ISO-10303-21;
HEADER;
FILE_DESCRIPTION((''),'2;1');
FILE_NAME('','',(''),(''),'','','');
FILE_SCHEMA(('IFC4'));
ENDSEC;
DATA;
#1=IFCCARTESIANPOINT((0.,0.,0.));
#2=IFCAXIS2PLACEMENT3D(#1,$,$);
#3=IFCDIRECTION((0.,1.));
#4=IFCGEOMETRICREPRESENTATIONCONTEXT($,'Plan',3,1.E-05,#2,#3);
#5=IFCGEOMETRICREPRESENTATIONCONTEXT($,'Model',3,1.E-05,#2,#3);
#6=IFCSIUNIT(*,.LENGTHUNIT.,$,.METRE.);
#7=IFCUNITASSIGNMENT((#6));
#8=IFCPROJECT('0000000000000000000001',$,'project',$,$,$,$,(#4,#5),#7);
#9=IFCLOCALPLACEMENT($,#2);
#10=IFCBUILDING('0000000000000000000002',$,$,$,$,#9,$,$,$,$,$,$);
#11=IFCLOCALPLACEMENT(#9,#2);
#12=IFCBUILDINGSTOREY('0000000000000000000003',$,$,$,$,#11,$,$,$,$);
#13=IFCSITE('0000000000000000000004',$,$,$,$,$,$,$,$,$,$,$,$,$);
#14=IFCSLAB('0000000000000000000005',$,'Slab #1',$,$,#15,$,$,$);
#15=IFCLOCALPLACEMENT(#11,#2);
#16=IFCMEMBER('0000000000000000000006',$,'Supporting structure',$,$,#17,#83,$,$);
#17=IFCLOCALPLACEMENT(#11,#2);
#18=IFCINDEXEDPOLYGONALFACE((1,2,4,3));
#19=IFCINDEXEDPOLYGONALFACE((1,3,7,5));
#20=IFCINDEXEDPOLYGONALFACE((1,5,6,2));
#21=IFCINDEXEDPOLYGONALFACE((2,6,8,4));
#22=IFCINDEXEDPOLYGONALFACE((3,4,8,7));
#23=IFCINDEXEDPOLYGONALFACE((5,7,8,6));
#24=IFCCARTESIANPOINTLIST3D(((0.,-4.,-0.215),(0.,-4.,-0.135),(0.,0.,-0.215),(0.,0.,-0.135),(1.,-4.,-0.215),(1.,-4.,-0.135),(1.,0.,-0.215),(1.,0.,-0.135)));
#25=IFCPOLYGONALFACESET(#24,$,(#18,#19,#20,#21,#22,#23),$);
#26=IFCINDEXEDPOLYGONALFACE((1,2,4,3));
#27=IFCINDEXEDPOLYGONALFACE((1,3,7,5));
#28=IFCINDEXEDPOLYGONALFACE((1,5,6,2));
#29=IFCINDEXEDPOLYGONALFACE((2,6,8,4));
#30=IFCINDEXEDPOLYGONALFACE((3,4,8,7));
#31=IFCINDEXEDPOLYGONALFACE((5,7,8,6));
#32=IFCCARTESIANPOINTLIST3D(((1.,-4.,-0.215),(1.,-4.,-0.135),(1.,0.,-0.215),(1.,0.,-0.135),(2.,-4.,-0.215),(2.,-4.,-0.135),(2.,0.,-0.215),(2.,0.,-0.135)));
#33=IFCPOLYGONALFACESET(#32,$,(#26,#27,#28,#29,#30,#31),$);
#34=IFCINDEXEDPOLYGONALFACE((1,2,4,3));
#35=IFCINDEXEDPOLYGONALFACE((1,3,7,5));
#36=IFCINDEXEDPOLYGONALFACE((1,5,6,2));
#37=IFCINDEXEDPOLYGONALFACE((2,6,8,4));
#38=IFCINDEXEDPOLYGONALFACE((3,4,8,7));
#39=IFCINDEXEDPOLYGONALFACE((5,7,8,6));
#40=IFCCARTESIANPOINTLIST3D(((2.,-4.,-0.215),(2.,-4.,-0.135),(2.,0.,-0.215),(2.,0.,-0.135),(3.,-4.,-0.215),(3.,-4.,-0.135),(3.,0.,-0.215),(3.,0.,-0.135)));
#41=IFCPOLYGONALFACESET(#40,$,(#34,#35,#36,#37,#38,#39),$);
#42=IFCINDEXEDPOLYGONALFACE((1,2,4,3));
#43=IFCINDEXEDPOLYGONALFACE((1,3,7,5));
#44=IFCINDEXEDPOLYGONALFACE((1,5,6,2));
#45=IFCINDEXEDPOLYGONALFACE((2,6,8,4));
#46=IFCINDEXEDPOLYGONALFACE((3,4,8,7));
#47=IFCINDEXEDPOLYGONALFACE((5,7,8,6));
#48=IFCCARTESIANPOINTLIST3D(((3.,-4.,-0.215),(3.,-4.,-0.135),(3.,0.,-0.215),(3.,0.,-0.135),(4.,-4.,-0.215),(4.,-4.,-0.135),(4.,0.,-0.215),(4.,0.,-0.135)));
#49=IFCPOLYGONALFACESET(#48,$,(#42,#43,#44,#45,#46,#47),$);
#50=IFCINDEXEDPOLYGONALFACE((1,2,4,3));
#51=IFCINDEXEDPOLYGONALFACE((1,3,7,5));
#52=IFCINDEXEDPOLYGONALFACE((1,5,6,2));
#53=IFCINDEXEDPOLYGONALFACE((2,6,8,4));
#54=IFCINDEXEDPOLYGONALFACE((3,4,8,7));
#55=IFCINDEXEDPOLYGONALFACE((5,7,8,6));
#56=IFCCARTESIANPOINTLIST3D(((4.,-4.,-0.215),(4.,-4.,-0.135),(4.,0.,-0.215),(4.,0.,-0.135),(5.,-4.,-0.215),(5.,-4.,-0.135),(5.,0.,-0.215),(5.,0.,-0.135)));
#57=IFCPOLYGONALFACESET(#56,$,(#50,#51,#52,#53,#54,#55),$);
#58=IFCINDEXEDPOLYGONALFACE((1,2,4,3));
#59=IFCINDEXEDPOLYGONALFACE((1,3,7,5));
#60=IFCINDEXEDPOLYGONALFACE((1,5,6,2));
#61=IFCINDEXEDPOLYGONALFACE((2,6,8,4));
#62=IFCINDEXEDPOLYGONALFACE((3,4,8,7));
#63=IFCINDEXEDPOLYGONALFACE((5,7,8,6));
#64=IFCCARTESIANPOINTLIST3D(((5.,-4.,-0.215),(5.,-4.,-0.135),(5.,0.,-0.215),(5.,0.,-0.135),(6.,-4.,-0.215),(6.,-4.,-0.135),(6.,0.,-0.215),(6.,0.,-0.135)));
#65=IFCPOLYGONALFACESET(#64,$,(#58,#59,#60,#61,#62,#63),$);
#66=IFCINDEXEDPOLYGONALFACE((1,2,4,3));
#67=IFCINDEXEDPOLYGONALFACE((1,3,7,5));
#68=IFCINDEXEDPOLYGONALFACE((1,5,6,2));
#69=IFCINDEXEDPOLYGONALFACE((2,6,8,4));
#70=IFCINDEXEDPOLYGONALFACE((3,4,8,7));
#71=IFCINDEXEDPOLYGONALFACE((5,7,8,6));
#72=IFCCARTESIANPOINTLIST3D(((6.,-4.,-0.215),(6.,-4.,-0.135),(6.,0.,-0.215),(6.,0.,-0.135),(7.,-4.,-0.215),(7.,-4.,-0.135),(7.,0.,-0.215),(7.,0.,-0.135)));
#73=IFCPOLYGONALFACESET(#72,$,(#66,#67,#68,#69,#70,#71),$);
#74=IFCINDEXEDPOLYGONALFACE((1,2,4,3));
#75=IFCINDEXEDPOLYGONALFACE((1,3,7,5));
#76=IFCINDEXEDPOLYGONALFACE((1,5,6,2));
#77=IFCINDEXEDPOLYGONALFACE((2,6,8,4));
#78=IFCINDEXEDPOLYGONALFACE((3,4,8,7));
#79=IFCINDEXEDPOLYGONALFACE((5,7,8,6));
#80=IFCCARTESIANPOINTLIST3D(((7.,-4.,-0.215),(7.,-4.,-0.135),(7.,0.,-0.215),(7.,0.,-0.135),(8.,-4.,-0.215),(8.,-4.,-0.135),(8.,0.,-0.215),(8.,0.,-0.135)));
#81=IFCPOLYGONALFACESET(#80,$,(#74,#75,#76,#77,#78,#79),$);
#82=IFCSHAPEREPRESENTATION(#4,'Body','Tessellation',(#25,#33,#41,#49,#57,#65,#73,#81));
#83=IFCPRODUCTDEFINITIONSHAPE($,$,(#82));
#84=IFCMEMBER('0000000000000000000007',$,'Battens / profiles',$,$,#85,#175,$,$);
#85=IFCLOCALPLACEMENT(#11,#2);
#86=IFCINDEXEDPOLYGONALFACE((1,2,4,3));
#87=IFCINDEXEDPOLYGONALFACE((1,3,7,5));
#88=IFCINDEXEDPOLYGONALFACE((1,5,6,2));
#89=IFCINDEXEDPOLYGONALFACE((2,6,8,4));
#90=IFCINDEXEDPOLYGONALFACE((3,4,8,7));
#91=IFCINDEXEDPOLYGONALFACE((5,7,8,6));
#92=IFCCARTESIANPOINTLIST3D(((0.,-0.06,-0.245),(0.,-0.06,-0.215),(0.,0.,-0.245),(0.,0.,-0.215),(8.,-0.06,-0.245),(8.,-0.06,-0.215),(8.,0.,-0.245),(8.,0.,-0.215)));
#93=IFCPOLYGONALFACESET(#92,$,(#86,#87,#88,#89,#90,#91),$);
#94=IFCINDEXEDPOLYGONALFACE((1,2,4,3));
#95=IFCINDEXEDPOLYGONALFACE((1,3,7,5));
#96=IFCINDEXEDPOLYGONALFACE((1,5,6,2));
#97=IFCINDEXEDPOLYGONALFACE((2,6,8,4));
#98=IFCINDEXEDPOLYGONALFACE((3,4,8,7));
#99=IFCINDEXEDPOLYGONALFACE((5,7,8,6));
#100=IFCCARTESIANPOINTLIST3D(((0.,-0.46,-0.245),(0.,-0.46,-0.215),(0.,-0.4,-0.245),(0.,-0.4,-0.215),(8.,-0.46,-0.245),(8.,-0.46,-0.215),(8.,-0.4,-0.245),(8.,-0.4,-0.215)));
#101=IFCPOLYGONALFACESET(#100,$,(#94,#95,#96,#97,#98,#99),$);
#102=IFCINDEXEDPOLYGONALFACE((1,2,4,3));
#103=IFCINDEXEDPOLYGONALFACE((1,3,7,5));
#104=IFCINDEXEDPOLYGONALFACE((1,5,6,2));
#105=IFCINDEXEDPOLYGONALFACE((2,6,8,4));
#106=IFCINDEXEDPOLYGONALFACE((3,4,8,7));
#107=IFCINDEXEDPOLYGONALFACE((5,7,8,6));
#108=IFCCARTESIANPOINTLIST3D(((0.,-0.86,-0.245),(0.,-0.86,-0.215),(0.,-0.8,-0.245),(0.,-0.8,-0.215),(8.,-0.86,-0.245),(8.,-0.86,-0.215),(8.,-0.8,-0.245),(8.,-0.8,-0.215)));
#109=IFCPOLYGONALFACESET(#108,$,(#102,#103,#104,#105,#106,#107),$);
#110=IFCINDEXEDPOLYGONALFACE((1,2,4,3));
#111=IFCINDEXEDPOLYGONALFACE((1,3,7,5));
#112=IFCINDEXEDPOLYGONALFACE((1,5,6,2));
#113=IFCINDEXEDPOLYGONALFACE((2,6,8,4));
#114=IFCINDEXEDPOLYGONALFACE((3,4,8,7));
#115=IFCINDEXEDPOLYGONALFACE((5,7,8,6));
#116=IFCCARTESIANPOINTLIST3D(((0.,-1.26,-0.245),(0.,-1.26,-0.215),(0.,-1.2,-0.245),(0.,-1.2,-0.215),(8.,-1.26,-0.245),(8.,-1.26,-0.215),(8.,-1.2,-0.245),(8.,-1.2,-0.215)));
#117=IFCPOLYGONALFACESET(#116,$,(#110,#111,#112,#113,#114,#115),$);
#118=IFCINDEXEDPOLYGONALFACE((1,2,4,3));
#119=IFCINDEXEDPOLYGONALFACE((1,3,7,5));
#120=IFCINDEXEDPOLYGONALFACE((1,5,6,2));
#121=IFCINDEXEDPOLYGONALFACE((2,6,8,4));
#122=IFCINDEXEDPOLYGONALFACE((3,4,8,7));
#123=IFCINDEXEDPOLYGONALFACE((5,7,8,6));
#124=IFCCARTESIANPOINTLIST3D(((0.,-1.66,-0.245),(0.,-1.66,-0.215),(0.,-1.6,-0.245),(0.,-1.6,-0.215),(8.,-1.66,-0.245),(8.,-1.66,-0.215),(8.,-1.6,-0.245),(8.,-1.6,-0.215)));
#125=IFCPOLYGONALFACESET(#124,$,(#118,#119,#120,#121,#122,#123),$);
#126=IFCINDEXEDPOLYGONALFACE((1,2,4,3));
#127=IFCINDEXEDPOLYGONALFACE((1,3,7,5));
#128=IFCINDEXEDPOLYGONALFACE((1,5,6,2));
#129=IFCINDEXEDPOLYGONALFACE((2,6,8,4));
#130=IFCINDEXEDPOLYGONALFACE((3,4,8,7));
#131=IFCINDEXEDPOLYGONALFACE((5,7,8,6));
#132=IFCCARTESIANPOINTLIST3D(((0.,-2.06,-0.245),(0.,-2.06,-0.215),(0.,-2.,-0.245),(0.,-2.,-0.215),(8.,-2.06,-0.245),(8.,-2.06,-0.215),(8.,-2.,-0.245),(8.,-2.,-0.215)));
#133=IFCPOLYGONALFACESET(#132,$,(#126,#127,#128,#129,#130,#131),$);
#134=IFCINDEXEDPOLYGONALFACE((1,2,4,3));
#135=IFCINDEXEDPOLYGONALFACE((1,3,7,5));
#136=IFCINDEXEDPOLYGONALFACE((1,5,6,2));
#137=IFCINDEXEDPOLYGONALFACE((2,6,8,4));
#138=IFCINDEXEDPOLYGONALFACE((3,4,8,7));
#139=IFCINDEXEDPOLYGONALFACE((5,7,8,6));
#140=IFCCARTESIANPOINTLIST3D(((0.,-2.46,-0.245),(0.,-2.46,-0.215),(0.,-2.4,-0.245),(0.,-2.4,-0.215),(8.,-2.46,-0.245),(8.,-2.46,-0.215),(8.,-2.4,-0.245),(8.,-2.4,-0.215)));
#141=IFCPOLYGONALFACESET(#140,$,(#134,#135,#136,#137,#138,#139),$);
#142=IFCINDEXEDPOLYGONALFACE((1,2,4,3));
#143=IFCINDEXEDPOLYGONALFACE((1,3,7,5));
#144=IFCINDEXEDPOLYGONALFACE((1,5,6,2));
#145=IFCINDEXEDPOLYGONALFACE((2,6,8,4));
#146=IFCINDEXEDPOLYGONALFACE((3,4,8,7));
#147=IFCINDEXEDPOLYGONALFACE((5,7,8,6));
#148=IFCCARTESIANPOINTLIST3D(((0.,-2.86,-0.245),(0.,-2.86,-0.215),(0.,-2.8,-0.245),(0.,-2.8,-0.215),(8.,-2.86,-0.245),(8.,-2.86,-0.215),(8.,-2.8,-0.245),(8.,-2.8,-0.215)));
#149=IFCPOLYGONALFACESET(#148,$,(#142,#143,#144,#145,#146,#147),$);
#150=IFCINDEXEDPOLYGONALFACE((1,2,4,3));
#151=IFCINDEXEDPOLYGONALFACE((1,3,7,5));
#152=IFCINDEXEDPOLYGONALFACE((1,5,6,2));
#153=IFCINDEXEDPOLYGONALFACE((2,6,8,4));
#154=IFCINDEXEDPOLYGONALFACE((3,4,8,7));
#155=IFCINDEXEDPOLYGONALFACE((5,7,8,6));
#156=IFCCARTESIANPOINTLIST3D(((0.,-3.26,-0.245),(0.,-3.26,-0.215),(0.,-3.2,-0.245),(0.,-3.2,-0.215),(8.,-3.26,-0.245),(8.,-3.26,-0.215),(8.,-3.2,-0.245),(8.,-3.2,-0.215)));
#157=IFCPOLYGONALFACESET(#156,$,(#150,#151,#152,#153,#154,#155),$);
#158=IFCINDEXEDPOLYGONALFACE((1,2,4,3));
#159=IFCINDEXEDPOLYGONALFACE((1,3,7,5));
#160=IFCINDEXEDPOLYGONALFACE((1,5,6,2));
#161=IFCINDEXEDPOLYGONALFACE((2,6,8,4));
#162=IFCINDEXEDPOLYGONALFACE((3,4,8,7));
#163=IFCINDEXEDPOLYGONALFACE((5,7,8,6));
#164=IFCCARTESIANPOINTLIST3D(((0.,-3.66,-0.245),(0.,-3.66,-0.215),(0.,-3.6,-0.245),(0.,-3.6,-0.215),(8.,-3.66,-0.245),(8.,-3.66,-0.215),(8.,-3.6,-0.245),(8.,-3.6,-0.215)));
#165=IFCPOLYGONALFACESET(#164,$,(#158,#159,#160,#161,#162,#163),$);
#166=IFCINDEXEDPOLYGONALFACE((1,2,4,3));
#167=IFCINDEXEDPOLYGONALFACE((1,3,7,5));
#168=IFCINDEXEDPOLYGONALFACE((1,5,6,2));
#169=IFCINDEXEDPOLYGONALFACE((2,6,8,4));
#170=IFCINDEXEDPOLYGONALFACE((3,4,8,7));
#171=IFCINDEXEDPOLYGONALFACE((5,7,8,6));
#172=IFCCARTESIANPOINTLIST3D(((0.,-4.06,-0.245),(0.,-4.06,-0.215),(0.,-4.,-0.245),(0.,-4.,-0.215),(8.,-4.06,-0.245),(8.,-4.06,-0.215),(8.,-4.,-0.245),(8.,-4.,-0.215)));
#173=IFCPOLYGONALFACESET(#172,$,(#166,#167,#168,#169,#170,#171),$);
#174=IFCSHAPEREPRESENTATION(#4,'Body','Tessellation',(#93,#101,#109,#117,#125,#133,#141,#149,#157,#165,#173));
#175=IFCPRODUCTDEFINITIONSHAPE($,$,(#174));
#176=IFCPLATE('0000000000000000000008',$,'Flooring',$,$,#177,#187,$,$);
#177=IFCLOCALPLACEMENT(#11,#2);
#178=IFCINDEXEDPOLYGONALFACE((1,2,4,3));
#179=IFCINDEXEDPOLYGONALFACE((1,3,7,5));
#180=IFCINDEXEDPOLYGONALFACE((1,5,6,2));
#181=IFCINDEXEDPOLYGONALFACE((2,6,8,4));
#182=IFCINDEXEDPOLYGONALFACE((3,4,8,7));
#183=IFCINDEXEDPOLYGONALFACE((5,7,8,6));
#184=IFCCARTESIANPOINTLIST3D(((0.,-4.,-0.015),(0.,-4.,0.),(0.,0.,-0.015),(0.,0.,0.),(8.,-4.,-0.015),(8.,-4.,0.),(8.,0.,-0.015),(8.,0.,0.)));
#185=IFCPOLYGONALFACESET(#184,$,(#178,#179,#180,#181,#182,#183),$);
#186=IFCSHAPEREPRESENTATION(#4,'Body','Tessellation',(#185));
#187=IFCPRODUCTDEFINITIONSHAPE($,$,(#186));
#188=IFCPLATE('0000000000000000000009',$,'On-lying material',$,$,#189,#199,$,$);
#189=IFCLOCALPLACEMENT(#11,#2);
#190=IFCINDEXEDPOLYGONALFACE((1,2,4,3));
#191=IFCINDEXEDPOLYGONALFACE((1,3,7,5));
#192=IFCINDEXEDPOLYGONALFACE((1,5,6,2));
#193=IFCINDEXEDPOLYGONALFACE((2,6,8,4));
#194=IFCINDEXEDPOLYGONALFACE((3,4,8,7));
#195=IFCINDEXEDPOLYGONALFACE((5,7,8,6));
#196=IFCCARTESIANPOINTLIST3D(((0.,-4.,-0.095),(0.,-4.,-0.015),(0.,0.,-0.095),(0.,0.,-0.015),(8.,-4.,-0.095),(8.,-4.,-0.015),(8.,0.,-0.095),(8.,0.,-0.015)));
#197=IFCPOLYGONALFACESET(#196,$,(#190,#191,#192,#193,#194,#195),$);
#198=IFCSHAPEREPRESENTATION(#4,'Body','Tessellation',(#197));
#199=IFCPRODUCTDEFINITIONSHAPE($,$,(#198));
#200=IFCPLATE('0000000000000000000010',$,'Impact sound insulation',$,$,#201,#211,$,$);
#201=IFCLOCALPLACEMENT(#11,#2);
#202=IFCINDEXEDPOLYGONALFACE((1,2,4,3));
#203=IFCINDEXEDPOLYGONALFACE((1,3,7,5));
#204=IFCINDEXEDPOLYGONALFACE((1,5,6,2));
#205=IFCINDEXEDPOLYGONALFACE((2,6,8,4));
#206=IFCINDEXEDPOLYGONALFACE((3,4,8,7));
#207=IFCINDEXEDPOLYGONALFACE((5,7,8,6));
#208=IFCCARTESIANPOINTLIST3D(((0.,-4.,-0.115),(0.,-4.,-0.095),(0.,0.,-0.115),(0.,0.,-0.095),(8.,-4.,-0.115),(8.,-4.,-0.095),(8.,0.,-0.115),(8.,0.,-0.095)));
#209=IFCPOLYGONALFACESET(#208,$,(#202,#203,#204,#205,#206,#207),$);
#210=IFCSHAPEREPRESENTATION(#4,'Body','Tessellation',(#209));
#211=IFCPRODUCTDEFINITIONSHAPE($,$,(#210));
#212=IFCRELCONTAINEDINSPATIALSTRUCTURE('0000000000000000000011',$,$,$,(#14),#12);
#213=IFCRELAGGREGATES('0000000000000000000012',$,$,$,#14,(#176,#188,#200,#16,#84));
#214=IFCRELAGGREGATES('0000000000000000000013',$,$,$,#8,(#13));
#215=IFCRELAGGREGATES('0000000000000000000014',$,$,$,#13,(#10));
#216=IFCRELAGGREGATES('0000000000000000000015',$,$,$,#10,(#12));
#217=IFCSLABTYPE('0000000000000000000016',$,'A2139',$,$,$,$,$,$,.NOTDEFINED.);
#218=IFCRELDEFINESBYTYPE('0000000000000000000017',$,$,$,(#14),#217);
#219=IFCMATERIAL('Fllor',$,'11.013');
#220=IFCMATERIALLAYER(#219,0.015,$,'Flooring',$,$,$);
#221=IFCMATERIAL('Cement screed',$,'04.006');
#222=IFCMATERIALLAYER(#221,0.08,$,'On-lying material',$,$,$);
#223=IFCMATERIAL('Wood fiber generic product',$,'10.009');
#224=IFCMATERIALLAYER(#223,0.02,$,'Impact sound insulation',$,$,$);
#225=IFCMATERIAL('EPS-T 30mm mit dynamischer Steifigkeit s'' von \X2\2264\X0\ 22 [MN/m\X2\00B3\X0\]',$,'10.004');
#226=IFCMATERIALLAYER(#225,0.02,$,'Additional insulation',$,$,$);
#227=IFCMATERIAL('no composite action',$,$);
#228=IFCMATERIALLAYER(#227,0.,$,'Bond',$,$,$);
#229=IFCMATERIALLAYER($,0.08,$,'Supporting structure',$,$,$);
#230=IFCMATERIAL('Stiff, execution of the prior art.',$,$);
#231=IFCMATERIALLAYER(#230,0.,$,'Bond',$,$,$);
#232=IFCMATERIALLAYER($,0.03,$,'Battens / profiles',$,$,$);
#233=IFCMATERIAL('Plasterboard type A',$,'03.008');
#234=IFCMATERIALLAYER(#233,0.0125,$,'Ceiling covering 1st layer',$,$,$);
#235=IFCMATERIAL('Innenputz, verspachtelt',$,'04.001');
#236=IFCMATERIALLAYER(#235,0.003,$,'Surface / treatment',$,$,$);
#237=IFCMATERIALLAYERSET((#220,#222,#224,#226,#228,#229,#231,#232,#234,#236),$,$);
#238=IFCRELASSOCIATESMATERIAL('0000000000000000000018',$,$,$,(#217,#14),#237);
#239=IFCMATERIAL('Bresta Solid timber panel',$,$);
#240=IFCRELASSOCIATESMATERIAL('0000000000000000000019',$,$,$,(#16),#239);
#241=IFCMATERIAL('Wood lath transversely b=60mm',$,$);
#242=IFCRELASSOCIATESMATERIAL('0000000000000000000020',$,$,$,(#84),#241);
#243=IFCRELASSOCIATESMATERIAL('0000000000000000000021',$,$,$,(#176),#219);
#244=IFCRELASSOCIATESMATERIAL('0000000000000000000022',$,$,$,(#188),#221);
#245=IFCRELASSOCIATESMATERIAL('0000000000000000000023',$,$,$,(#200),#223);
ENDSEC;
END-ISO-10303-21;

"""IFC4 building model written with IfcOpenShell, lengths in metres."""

from ifc_helpers import new_model, si_unit, direction, frame, frame_2d, origin, origin_with_axes, place, context, project, spatial, rectangle, extrude, material, layer, layer_set, type_object, element, aggregate, save


model = new_model("IFC4")

# Units and contexts
plan_context = context("Plan", 3, precision=1e-05, world=origin(), true_north=direction((0.0, 1.0)))
model_context = context("Model", 3, precision=1e-05, world=origin(), true_north=direction((0.0, 1.0)))
ifc_project = project(units=[si_unit("LENGTHUNIT", "METRE")], contexts=[plan_context, model_context])

# Site, building, storey
site = spatial("IfcSite", under=ifc_project)
building_placement = place(None, origin())
building = spatial("IfcBuilding", under=site, at=building_placement)
storey_placement = place(building_placement, origin())
storey = spatial("IfcBuildingStorey", under=building, at=storey_placement)

# Slab, members, plates
ifc_material_1 = material(Name="Fllor", Category="11.013")
ifc_layer_1 = layer(ifc_material_1, 0.015, Name="Flooring")
ifc_material_2 = material(Name="Cement screed", Category="04.006")
ifc_layer_2 = layer(ifc_material_2, 0.08, Name="On-lying material")
ifc_material_3 = material(Name="Wood fiber generic product", Category="10.009")
ifc_layer_3 = layer(ifc_material_3, 0.02, Name="Impact sound insulation")
ifc_material_4 = material(Name="EPS-T 30mm mit dynamischer Steifigkeit s' von ≤ 22 [MN/m³]", Category="10.004")
ifc_layer_4 = layer(ifc_material_4, 0.02, Name="Additional insulation")
ifc_material_5 = material(Name="no composite action")
ifc_layer_5 = layer(ifc_material_5, 0.0, Name="Bond")
ifc_layer_6 = layer(None, 0.08, Name="Supporting structure")
ifc_material_6 = material(Name="Stiff, execution of the prior art.")
ifc_layer_7 = layer(ifc_material_6, 0.0, Name="Bond")
ifc_layer_8 = layer(None, 0.03, Name="Battens / profiles")
ifc_material_7 = material(Name="Plasterboard type A", Category="03.008")
ifc_layer_9 = layer(ifc_material_7, 0.0125, Name="Ceiling covering 1st layer")
ifc_material_8 = material(Name="Innenputz, verspachtelt", Category="04.001")
ifc_layer_10 = layer(ifc_material_8, 0.003, Name="Surface / treatment")
ifc_layer_set = layer_set([ifc_layer_1, ifc_layer_2, ifc_layer_3, ifc_layer_4, ifc_layer_5, ifc_layer_6, ifc_layer_7, ifc_layer_8, ifc_layer_9, ifc_layer_10])
slab_type = type_object("IfcSlabType", Name="A2139", PredefinedType="NOTDEFINED", material=ifc_layer_set)
slab_placement = place(None, frame((0.0, 0.0, 0.0), z_axis=(0.0, 0.0, -1.0), x_axis=(1.0, 0.0, 0.0)))
slab = element("IfcSlab", 1, at=slab_placement, inside=storey, type_object=slab_type, material=ifc_layer_set, Name="Slab #1")
ifc_material_9 = material(Name="Bresta Solid timber panel")
member_1_placement = place(slab_placement, origin())
member_1 = element("IfcMember", 2, at=member_1_placement, material=ifc_material_9, Name="Supporting structure", context=plan_context, shape_type="SweptSolid", body=[
    extrude(rectangle(XDim=1.0, YDim=0.08, at=frame_2d((0.5, 0.04), x_axis=(1.0, 0.0))), frame((0.0, 4.0, 0.135), z_axis=(0.0, -1.0, 0.0), x_axis=(1.0, 0.0, 0.0)), (0.0, 0.0, 1.0), 4.0),
    extrude(rectangle(XDim=1.0, YDim=0.08, at=frame_2d((0.5, 0.04), x_axis=(1.0, 0.0))), frame((1.0, 4.0, 0.135), z_axis=(0.0, -1.0, 0.0), x_axis=(1.0, 0.0, 0.0)), (0.0, 0.0, 1.0), 4.0),
    extrude(rectangle(XDim=1.0, YDim=0.08, at=frame_2d((0.5, 0.04), x_axis=(1.0, 0.0))), frame((2.0, 4.0, 0.135), z_axis=(0.0, -1.0, 0.0), x_axis=(1.0, 0.0, 0.0)), (0.0, 0.0, 1.0), 4.0),
    extrude(rectangle(XDim=1.0, YDim=0.08, at=frame_2d((0.5, 0.04), x_axis=(1.0, 0.0))), frame((3.0, 4.0, 0.135), z_axis=(0.0, -1.0, 0.0), x_axis=(1.0, 0.0, 0.0)), (0.0, 0.0, 1.0), 4.0),
    extrude(rectangle(XDim=1.0, YDim=0.08, at=frame_2d((0.5, 0.04), x_axis=(1.0, 0.0))), frame((4.0, 4.0, 0.135), z_axis=(0.0, -1.0, 0.0), x_axis=(1.0, 0.0, 0.0)), (0.0, 0.0, 1.0), 4.0),
    extrude(rectangle(XDim=1.0, YDim=0.08, at=frame_2d((0.5, 0.04), x_axis=(1.0, 0.0))), frame((5.0, 4.0, 0.135), z_axis=(0.0, -1.0, 0.0), x_axis=(1.0, 0.0, 0.0)), (0.0, 0.0, 1.0), 4.0),
    extrude(rectangle(XDim=1.0, YDim=0.08, at=frame_2d((0.5, 0.04), x_axis=(1.0, 0.0))), frame((6.0, 4.0, 0.135), z_axis=(0.0, -1.0, 0.0), x_axis=(1.0, 0.0, 0.0)), (0.0, 0.0, 1.0), 4.0),
    extrude(rectangle(XDim=1.0, YDim=0.08, at=frame_2d((0.5, 0.04), x_axis=(1.0, 0.0))), frame((7.0, 4.0, 0.135), z_axis=(0.0, -1.0, 0.0), x_axis=(1.0, 0.0, 0.0)), (0.0, 0.0, 1.0), 4.0),
])
ifc_material_10 = material(Name="Wood lath transversely b=60mm")
member_2_placement = place(slab_placement, origin())
member_2 = element("IfcMember", 3, at=member_2_placement, material=ifc_material_10, Name="Battens / profiles", context=plan_context, shape_type="SweptSolid", body=[
    extrude(rectangle(XDim=0.06, YDim=0.03, at=frame_2d((0.03, 0.015), x_axis=(1.0, 0.0))), frame((0.0, 0.0, 0.215), z_axis=(1.0, 0.0, 0.0), x_axis=(0.0, 1.0, 0.0)), (0.0, 0.0, 1.0), 8.0),
    extrude(rectangle(XDim=0.06, YDim=0.03, at=frame_2d((0.03, 0.015), x_axis=(1.0, 0.0))), frame((0.0, 0.4, 0.215), z_axis=(1.0, 0.0, 0.0), x_axis=(0.0, 1.0, 0.0)), (0.0, 0.0, 1.0), 8.0),
    extrude(rectangle(XDim=0.06, YDim=0.03, at=frame_2d((0.03, 0.015), x_axis=(1.0, 0.0))), frame((0.0, 0.8, 0.215), z_axis=(1.0, 0.0, 0.0), x_axis=(0.0, 1.0, 0.0)), (0.0, 0.0, 1.0), 8.0),
    extrude(rectangle(XDim=0.06, YDim=0.03, at=frame_2d((0.03, 0.015), x_axis=(1.0, 0.0))), frame((0.0, 1.2, 0.215), z_axis=(1.0, 0.0, 0.0), x_axis=(0.0, 1.0, 0.0)), (0.0, 0.0, 1.0), 8.0),
    extrude(rectangle(XDim=0.06, YDim=0.03, at=frame_2d((0.03, 0.015), x_axis=(1.0, 0.0))), frame((0.0, 1.6, 0.215), z_axis=(1.0, 0.0, 0.0), x_axis=(0.0, 1.0, 0.0)), (0.0, 0.0, 1.0), 8.0),
    extrude(rectangle(XDim=0.06, YDim=0.03, at=frame_2d((0.03, 0.015), x_axis=(1.0, 0.0))), frame((0.0, 2.0, 0.215), z_axis=(1.0, 0.0, 0.0), x_axis=(0.0, 1.0, 0.0)), (0.0, 0.0, 1.0), 8.0),
    extrude(rectangle(XDim=0.06, YDim=0.03, at=frame_2d((0.03, 0.015), x_axis=(1.0, 0.0))), frame((0.0, 2.4, 0.215), z_axis=(1.0, 0.0, 0.0), x_axis=(0.0, 1.0, 0.0)), (0.0, 0.0, 1.0), 8.0),
    extrude(rectangle(XDim=0.06, YDim=0.03, at=frame_2d((0.03, 0.015), x_axis=(1.0, 0.0))), frame((0.0, 2.8, 0.215), z_axis=(1.0, 0.0, 0.0), x_axis=(0.0, 1.0, 0.0)), (0.0, 0.0, 1.0), 8.0),
    extrude(rectangle(XDim=0.06, YDim=0.03, at=frame_2d((0.03, 0.015), x_axis=(1.0, 0.0))), frame((0.0, 3.2, 0.215), z_axis=(1.0, 0.0, 0.0), x_axis=(0.0, 1.0, 0.0)), (0.0, 0.0, 1.0), 8.0),
    extrude(rectangle(XDim=0.06, YDim=0.03, at=frame_2d((0.03, 0.015), x_axis=(1.0, 0.0))), frame((0.0, 3.6, 0.215), z_axis=(1.0, 0.0, 0.0), x_axis=(0.0, 1.0, 0.0)), (0.0, 0.0, 1.0), 8.0),
    extrude(rectangle(XDim=0.06, YDim=0.03, at=frame_2d((0.03, 0.015), x_axis=(1.0, 0.0))), frame((0.0, 4.0, 0.215), z_axis=(1.0, 0.0, 0.0), x_axis=(0.0, 1.0, 0.0)), (0.0, 0.0, 1.0), 8.0),
])
plate_1_placement = place(slab_placement, origin())
plate_1 = element("IfcPlate", 4, at=plate_1_placement, material=ifc_material_1, Name="Flooring", context=plan_context, shape_type="SweptSolid", body=[
    extrude(rectangle(XDim=8.0, YDim=4.0, at=frame_2d((4.0, 2.0), x_axis=(1.0, 0.0))), origin_with_axes(), (0.0, 0.0, 1.0), 0.015),
])
plate_2_placement = place(slab_placement, origin())
plate_2 = element("IfcPlate", 5, at=plate_2_placement, material=ifc_material_2, Name="On-lying material", context=plan_context, shape_type="SweptSolid", body=[
    extrude(rectangle(XDim=8.0, YDim=4.0, at=frame_2d((4.0, 2.0), x_axis=(1.0, 0.0))), frame((0.0, 0.0, 0.015), z_axis=(0.0, 0.0, 1.0), x_axis=(1.0, 0.0, 0.0)), (0.0, 0.0, 1.0), 0.08),
])
plate_3_placement = place(slab_placement, origin())
plate_3 = element("IfcPlate", 6, at=plate_3_placement, material=ifc_material_3, Name="Impact sound insulation", context=plan_context, shape_type="SweptSolid", body=[
    extrude(rectangle(XDim=8.0, YDim=4.0, at=frame_2d((4.0, 2.0), x_axis=(1.0, 0.0))), frame((0.0, 0.0, 0.095), z_axis=(0.0, 0.0, 1.0), x_axis=(1.0, 0.0, 0.0)), (0.0, 0.0, 1.0), 0.02),
])
aggregate(slab, [plate_1, plate_2, plate_3, member_1, member_2])

save(model, "model.ifc")
